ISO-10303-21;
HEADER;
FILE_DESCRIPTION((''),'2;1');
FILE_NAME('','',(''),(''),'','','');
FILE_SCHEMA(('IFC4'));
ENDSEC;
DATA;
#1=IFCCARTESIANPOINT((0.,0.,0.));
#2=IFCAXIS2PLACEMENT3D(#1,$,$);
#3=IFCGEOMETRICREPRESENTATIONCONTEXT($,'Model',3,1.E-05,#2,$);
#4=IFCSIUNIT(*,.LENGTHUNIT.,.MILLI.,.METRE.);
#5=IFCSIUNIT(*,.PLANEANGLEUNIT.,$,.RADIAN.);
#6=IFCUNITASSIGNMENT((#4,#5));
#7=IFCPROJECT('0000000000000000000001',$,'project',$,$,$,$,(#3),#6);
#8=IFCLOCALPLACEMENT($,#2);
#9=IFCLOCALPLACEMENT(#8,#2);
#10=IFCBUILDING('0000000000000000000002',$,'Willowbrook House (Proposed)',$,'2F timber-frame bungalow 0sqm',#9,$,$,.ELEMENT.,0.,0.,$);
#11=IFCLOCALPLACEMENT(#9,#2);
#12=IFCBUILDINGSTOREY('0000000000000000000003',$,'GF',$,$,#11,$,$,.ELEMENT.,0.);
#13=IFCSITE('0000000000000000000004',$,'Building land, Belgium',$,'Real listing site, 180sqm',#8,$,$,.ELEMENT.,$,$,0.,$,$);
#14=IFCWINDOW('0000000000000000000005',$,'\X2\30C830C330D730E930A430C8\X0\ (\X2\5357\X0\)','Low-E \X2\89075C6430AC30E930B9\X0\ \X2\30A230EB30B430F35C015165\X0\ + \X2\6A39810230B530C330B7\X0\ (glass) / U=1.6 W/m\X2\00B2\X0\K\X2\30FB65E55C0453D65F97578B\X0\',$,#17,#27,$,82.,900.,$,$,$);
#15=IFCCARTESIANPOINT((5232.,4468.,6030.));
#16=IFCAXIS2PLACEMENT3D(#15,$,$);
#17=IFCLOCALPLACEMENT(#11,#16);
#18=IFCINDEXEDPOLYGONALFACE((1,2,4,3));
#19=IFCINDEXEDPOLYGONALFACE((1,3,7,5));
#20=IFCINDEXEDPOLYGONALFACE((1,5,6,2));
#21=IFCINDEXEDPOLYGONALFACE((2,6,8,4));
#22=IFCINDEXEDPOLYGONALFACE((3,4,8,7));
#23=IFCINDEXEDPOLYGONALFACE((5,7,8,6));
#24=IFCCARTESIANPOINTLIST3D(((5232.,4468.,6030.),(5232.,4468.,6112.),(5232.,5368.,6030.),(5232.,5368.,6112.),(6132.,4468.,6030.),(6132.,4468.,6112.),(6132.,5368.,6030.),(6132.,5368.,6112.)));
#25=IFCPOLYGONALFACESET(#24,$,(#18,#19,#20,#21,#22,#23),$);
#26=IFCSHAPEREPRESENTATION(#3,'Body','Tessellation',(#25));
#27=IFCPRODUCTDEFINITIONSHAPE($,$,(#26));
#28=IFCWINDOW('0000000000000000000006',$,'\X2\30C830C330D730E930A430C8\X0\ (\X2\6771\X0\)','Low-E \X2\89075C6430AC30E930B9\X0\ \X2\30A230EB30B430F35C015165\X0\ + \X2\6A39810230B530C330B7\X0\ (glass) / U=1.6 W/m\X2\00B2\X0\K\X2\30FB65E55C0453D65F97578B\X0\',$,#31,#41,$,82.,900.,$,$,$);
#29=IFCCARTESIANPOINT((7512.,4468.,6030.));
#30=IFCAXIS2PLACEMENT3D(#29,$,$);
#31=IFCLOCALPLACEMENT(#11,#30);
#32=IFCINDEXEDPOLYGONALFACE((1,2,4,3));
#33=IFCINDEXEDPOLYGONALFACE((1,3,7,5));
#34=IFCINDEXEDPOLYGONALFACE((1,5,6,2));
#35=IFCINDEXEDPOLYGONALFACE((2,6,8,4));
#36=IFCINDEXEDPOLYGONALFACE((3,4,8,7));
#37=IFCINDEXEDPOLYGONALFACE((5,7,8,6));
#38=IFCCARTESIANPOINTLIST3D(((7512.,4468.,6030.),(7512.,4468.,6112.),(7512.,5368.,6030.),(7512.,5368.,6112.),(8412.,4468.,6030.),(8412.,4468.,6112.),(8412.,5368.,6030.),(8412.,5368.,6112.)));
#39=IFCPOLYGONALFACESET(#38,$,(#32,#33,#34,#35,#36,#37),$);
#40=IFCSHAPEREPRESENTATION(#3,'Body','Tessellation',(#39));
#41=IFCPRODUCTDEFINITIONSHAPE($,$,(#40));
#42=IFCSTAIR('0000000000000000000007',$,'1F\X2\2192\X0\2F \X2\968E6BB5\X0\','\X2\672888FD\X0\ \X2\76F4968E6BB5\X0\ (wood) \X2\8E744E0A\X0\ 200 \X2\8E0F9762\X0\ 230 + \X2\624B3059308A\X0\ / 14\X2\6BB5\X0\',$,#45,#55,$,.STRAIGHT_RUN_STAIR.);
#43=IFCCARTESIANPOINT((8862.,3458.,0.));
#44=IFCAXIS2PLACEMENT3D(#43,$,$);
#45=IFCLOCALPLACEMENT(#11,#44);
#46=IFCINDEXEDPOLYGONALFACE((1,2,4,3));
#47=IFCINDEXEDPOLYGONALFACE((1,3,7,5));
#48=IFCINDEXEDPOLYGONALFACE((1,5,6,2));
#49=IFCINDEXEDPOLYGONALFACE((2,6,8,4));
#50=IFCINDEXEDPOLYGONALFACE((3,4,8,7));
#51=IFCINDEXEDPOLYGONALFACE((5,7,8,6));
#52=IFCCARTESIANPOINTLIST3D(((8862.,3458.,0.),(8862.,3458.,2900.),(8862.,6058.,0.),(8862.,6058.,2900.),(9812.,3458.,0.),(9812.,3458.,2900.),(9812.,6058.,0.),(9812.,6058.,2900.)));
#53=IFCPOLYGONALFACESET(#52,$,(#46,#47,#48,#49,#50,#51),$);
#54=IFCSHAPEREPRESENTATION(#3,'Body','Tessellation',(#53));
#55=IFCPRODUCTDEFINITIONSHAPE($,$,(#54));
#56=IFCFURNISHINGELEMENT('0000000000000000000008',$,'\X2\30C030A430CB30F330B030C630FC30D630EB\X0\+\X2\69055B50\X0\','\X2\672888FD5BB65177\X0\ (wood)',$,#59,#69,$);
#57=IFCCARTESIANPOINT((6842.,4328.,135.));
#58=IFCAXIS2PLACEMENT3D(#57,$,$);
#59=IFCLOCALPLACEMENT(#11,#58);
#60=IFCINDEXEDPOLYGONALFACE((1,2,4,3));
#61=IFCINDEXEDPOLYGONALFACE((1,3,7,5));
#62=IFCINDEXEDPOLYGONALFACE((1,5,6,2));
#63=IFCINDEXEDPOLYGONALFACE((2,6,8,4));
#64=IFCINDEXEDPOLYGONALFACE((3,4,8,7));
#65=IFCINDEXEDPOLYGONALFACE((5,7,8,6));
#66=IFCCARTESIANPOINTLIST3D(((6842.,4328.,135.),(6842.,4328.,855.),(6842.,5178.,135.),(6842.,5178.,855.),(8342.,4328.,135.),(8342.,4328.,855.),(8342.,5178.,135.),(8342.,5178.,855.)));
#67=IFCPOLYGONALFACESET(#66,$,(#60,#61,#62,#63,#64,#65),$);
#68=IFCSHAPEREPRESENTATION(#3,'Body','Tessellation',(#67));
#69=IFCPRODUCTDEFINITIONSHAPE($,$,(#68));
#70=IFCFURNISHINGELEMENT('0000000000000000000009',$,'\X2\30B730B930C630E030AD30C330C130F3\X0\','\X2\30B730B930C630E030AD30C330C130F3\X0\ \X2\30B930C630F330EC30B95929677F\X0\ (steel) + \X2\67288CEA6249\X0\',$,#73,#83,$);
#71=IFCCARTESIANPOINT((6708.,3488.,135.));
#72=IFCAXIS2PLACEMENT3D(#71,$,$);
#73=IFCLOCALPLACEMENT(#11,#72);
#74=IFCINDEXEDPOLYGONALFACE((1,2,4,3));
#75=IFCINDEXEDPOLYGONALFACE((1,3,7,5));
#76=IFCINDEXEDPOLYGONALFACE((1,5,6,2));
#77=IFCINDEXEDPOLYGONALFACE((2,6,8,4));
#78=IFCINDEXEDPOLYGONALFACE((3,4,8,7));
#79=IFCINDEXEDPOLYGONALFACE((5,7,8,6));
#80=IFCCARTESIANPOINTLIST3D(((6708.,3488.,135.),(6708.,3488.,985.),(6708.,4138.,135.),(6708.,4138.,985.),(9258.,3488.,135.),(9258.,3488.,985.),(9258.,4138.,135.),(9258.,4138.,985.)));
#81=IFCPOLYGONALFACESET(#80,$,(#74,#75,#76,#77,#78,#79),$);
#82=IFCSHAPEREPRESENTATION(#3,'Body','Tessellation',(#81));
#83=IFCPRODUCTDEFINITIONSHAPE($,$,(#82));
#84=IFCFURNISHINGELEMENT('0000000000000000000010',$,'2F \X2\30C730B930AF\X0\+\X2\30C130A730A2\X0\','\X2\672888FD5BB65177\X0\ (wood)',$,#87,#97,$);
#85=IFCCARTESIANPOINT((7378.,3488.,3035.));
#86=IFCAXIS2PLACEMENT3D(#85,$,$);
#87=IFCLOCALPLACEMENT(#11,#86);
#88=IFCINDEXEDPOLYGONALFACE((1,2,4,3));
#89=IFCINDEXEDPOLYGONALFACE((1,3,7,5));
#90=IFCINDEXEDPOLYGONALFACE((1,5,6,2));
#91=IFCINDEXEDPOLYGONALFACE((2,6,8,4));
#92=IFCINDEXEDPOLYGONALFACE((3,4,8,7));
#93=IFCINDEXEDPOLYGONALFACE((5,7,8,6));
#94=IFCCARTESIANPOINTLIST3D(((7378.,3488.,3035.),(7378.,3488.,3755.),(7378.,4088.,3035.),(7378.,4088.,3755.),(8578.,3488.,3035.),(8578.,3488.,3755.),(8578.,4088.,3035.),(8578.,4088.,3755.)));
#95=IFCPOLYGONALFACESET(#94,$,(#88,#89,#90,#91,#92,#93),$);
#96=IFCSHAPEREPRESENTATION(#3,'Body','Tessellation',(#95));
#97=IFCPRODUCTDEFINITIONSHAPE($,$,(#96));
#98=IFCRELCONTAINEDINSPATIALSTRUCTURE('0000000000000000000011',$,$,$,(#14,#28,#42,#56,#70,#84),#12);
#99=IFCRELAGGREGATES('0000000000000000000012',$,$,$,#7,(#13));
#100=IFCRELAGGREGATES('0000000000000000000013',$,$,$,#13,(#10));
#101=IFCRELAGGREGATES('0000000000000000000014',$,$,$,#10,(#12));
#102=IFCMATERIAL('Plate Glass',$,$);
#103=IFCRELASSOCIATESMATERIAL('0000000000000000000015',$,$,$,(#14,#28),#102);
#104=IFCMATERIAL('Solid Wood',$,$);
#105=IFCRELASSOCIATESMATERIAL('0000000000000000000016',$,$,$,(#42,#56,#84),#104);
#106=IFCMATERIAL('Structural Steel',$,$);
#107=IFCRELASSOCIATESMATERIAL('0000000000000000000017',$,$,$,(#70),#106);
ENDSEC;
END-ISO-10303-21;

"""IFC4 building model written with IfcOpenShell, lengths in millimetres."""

from ifc_helpers import new_model, si_unit, frame, frame_2d, origin, place, context, project, spatial, rectangle, extrude, material, element, save


model = new_model("IFC4")

# Units and contexts
model_context = context("Model", 3, precision=1e-05, world=origin())
ifc_project = project(units=[si_unit("LENGTHUNIT", "METRE", prefix="MILLI"), si_unit("PLANEANGLEUNIT", "RADIAN")], contexts=[model_context])

# Site, building, storey
site_placement = place(None, origin())
site = spatial("IfcSite", under=ifc_project, at=site_placement, Name="Building land, Belgium", ObjectType="Real listing site, 180sqm", CompositionType="ELEMENT", RefElevation=0.0)
building_placement = place(site_placement, origin())
building = spatial("IfcBuilding", under=site, at=building_placement, Name="Willowbrook House (Proposed)", ObjectType="2F timber-frame bungalow 0sqm", CompositionType="ELEMENT", ElevationOfRefHeight=0.0, ElevationOfTerrain=0.0)
storey_placement = place(building_placement, origin())
storey = spatial("IfcBuildingStorey", under=building, at=storey_placement, Name="GF", CompositionType="ELEMENT", Elevation=0.0)

# Shared definitions
ifc_material_1 = material(Name="Solid Wood")

# Shared definitions
ifc_material_2 = material(Name="Plate Glass")

# Windows
window_1_placement = place(storey_placement, frame((5232.0, 4468.0, 6030.0)))
element("IfcWindow", 1, at=window_1_placement, inside=storey, material=ifc_material_2, Name="トップライト (南)", Description="Low-E 複層ガラス アルゴン封入 + 樹脂サッシ (glass) / U=1.6 W/m²K・日射取得型", OverallHeight=82.0, OverallWidth=900.0, context=model_context, shape_type="SweptSolid", body=[
    extrude(rectangle(XDim=900.0, YDim=900.0, at=frame_2d((450.0, 450.0))), frame((5232.0, 4468.0, 6030.0)), (0.0, 0.0, 1.0), 82.0),
])
window_2_placement = place(storey_placement, frame((7512.0, 4468.0, 6030.0)))
element("IfcWindow", 2, at=window_2_placement, inside=storey, material=ifc_material_2, Name="トップライト (東)", Description="Low-E 複層ガラス アルゴン封入 + 樹脂サッシ (glass) / U=1.6 W/m²K・日射取得型", OverallHeight=82.0, OverallWidth=900.0, context=model_context, shape_type="SweptSolid", body=[
    extrude(rectangle(XDim=900.0, YDim=900.0, at=frame_2d((450.0, 450.0))), frame((7512.0, 4468.0, 6030.0)), (0.0, 0.0, 1.0), 82.0),
])

# Stair
stair_placement = place(storey_placement, frame((8862.0, 3458.0, 0.0)))
element("IfcStair", 3, at=stair_placement, inside=storey, material=ifc_material_1, Name="1F→2F 階段", Description="木製 直階段 (wood) 蹴上 200 踏面 230 + 手すり / 14段", PredefinedType="STRAIGHT_RUN_STAIR", context=model_context, shape_type="SweptSolid", body=[
    extrude(rectangle(XDim=950.0, YDim=2600.0, at=frame_2d((475.0, 1300.0))), frame((8862.0, 3458.0, 0.0)), (0.0, 0.0, 1.0), 2900.0),
])

# Furnishing elements
furnishing_1_placement = place(storey_placement, frame((6842.0, 4328.0, 135.0)))
element("IfcFurnishingElement", 4, at=furnishing_1_placement, inside=storey, material=ifc_material_1, Name="ダイニングテーブル+椅子", Description="木製家具 (wood)", context=model_context, shape_type="SweptSolid", body=[
    extrude(rectangle(XDim=1500.0, YDim=850.0, at=frame_2d((750.0, 425.0))), frame((6842.0, 4328.0, 135.0)), (0.0, 0.0, 1.0), 720.0),
])
ifc_material_3 = material(Name="Structural Steel")
furnishing_2_placement = place(storey_placement, frame((6708.0, 3488.0, 135.0)))
element("IfcFurnishingElement", 5, at=furnishing_2_placement, inside=storey, material=ifc_material_3, Name="システムキッチン", Description="システムキッチン ステンレス天板 (steel) + 木質扉", context=model_context, shape_type="SweptSolid", body=[
    extrude(rectangle(XDim=2550.0, YDim=650.0, at=frame_2d((1275.0, 325.0))), frame((6708.0, 3488.0, 135.0)), (0.0, 0.0, 1.0), 850.0),
])
furnishing_3_placement = place(storey_placement, frame((7378.0, 3488.0, 3035.0)))
element("IfcFurnishingElement", 6, at=furnishing_3_placement, inside=storey, material=ifc_material_1, Name="2F デスク+チェア", Description="木製家具 (wood)", context=model_context, shape_type="SweptSolid", body=[
    extrude(rectangle(XDim=1200.0, YDim=600.0, at=frame_2d((600.0, 300.0))), frame((7378.0, 3488.0, 3035.0)), (0.0, 0.0, 1.0), 720.0),
])

save(model, "model.ifc")
